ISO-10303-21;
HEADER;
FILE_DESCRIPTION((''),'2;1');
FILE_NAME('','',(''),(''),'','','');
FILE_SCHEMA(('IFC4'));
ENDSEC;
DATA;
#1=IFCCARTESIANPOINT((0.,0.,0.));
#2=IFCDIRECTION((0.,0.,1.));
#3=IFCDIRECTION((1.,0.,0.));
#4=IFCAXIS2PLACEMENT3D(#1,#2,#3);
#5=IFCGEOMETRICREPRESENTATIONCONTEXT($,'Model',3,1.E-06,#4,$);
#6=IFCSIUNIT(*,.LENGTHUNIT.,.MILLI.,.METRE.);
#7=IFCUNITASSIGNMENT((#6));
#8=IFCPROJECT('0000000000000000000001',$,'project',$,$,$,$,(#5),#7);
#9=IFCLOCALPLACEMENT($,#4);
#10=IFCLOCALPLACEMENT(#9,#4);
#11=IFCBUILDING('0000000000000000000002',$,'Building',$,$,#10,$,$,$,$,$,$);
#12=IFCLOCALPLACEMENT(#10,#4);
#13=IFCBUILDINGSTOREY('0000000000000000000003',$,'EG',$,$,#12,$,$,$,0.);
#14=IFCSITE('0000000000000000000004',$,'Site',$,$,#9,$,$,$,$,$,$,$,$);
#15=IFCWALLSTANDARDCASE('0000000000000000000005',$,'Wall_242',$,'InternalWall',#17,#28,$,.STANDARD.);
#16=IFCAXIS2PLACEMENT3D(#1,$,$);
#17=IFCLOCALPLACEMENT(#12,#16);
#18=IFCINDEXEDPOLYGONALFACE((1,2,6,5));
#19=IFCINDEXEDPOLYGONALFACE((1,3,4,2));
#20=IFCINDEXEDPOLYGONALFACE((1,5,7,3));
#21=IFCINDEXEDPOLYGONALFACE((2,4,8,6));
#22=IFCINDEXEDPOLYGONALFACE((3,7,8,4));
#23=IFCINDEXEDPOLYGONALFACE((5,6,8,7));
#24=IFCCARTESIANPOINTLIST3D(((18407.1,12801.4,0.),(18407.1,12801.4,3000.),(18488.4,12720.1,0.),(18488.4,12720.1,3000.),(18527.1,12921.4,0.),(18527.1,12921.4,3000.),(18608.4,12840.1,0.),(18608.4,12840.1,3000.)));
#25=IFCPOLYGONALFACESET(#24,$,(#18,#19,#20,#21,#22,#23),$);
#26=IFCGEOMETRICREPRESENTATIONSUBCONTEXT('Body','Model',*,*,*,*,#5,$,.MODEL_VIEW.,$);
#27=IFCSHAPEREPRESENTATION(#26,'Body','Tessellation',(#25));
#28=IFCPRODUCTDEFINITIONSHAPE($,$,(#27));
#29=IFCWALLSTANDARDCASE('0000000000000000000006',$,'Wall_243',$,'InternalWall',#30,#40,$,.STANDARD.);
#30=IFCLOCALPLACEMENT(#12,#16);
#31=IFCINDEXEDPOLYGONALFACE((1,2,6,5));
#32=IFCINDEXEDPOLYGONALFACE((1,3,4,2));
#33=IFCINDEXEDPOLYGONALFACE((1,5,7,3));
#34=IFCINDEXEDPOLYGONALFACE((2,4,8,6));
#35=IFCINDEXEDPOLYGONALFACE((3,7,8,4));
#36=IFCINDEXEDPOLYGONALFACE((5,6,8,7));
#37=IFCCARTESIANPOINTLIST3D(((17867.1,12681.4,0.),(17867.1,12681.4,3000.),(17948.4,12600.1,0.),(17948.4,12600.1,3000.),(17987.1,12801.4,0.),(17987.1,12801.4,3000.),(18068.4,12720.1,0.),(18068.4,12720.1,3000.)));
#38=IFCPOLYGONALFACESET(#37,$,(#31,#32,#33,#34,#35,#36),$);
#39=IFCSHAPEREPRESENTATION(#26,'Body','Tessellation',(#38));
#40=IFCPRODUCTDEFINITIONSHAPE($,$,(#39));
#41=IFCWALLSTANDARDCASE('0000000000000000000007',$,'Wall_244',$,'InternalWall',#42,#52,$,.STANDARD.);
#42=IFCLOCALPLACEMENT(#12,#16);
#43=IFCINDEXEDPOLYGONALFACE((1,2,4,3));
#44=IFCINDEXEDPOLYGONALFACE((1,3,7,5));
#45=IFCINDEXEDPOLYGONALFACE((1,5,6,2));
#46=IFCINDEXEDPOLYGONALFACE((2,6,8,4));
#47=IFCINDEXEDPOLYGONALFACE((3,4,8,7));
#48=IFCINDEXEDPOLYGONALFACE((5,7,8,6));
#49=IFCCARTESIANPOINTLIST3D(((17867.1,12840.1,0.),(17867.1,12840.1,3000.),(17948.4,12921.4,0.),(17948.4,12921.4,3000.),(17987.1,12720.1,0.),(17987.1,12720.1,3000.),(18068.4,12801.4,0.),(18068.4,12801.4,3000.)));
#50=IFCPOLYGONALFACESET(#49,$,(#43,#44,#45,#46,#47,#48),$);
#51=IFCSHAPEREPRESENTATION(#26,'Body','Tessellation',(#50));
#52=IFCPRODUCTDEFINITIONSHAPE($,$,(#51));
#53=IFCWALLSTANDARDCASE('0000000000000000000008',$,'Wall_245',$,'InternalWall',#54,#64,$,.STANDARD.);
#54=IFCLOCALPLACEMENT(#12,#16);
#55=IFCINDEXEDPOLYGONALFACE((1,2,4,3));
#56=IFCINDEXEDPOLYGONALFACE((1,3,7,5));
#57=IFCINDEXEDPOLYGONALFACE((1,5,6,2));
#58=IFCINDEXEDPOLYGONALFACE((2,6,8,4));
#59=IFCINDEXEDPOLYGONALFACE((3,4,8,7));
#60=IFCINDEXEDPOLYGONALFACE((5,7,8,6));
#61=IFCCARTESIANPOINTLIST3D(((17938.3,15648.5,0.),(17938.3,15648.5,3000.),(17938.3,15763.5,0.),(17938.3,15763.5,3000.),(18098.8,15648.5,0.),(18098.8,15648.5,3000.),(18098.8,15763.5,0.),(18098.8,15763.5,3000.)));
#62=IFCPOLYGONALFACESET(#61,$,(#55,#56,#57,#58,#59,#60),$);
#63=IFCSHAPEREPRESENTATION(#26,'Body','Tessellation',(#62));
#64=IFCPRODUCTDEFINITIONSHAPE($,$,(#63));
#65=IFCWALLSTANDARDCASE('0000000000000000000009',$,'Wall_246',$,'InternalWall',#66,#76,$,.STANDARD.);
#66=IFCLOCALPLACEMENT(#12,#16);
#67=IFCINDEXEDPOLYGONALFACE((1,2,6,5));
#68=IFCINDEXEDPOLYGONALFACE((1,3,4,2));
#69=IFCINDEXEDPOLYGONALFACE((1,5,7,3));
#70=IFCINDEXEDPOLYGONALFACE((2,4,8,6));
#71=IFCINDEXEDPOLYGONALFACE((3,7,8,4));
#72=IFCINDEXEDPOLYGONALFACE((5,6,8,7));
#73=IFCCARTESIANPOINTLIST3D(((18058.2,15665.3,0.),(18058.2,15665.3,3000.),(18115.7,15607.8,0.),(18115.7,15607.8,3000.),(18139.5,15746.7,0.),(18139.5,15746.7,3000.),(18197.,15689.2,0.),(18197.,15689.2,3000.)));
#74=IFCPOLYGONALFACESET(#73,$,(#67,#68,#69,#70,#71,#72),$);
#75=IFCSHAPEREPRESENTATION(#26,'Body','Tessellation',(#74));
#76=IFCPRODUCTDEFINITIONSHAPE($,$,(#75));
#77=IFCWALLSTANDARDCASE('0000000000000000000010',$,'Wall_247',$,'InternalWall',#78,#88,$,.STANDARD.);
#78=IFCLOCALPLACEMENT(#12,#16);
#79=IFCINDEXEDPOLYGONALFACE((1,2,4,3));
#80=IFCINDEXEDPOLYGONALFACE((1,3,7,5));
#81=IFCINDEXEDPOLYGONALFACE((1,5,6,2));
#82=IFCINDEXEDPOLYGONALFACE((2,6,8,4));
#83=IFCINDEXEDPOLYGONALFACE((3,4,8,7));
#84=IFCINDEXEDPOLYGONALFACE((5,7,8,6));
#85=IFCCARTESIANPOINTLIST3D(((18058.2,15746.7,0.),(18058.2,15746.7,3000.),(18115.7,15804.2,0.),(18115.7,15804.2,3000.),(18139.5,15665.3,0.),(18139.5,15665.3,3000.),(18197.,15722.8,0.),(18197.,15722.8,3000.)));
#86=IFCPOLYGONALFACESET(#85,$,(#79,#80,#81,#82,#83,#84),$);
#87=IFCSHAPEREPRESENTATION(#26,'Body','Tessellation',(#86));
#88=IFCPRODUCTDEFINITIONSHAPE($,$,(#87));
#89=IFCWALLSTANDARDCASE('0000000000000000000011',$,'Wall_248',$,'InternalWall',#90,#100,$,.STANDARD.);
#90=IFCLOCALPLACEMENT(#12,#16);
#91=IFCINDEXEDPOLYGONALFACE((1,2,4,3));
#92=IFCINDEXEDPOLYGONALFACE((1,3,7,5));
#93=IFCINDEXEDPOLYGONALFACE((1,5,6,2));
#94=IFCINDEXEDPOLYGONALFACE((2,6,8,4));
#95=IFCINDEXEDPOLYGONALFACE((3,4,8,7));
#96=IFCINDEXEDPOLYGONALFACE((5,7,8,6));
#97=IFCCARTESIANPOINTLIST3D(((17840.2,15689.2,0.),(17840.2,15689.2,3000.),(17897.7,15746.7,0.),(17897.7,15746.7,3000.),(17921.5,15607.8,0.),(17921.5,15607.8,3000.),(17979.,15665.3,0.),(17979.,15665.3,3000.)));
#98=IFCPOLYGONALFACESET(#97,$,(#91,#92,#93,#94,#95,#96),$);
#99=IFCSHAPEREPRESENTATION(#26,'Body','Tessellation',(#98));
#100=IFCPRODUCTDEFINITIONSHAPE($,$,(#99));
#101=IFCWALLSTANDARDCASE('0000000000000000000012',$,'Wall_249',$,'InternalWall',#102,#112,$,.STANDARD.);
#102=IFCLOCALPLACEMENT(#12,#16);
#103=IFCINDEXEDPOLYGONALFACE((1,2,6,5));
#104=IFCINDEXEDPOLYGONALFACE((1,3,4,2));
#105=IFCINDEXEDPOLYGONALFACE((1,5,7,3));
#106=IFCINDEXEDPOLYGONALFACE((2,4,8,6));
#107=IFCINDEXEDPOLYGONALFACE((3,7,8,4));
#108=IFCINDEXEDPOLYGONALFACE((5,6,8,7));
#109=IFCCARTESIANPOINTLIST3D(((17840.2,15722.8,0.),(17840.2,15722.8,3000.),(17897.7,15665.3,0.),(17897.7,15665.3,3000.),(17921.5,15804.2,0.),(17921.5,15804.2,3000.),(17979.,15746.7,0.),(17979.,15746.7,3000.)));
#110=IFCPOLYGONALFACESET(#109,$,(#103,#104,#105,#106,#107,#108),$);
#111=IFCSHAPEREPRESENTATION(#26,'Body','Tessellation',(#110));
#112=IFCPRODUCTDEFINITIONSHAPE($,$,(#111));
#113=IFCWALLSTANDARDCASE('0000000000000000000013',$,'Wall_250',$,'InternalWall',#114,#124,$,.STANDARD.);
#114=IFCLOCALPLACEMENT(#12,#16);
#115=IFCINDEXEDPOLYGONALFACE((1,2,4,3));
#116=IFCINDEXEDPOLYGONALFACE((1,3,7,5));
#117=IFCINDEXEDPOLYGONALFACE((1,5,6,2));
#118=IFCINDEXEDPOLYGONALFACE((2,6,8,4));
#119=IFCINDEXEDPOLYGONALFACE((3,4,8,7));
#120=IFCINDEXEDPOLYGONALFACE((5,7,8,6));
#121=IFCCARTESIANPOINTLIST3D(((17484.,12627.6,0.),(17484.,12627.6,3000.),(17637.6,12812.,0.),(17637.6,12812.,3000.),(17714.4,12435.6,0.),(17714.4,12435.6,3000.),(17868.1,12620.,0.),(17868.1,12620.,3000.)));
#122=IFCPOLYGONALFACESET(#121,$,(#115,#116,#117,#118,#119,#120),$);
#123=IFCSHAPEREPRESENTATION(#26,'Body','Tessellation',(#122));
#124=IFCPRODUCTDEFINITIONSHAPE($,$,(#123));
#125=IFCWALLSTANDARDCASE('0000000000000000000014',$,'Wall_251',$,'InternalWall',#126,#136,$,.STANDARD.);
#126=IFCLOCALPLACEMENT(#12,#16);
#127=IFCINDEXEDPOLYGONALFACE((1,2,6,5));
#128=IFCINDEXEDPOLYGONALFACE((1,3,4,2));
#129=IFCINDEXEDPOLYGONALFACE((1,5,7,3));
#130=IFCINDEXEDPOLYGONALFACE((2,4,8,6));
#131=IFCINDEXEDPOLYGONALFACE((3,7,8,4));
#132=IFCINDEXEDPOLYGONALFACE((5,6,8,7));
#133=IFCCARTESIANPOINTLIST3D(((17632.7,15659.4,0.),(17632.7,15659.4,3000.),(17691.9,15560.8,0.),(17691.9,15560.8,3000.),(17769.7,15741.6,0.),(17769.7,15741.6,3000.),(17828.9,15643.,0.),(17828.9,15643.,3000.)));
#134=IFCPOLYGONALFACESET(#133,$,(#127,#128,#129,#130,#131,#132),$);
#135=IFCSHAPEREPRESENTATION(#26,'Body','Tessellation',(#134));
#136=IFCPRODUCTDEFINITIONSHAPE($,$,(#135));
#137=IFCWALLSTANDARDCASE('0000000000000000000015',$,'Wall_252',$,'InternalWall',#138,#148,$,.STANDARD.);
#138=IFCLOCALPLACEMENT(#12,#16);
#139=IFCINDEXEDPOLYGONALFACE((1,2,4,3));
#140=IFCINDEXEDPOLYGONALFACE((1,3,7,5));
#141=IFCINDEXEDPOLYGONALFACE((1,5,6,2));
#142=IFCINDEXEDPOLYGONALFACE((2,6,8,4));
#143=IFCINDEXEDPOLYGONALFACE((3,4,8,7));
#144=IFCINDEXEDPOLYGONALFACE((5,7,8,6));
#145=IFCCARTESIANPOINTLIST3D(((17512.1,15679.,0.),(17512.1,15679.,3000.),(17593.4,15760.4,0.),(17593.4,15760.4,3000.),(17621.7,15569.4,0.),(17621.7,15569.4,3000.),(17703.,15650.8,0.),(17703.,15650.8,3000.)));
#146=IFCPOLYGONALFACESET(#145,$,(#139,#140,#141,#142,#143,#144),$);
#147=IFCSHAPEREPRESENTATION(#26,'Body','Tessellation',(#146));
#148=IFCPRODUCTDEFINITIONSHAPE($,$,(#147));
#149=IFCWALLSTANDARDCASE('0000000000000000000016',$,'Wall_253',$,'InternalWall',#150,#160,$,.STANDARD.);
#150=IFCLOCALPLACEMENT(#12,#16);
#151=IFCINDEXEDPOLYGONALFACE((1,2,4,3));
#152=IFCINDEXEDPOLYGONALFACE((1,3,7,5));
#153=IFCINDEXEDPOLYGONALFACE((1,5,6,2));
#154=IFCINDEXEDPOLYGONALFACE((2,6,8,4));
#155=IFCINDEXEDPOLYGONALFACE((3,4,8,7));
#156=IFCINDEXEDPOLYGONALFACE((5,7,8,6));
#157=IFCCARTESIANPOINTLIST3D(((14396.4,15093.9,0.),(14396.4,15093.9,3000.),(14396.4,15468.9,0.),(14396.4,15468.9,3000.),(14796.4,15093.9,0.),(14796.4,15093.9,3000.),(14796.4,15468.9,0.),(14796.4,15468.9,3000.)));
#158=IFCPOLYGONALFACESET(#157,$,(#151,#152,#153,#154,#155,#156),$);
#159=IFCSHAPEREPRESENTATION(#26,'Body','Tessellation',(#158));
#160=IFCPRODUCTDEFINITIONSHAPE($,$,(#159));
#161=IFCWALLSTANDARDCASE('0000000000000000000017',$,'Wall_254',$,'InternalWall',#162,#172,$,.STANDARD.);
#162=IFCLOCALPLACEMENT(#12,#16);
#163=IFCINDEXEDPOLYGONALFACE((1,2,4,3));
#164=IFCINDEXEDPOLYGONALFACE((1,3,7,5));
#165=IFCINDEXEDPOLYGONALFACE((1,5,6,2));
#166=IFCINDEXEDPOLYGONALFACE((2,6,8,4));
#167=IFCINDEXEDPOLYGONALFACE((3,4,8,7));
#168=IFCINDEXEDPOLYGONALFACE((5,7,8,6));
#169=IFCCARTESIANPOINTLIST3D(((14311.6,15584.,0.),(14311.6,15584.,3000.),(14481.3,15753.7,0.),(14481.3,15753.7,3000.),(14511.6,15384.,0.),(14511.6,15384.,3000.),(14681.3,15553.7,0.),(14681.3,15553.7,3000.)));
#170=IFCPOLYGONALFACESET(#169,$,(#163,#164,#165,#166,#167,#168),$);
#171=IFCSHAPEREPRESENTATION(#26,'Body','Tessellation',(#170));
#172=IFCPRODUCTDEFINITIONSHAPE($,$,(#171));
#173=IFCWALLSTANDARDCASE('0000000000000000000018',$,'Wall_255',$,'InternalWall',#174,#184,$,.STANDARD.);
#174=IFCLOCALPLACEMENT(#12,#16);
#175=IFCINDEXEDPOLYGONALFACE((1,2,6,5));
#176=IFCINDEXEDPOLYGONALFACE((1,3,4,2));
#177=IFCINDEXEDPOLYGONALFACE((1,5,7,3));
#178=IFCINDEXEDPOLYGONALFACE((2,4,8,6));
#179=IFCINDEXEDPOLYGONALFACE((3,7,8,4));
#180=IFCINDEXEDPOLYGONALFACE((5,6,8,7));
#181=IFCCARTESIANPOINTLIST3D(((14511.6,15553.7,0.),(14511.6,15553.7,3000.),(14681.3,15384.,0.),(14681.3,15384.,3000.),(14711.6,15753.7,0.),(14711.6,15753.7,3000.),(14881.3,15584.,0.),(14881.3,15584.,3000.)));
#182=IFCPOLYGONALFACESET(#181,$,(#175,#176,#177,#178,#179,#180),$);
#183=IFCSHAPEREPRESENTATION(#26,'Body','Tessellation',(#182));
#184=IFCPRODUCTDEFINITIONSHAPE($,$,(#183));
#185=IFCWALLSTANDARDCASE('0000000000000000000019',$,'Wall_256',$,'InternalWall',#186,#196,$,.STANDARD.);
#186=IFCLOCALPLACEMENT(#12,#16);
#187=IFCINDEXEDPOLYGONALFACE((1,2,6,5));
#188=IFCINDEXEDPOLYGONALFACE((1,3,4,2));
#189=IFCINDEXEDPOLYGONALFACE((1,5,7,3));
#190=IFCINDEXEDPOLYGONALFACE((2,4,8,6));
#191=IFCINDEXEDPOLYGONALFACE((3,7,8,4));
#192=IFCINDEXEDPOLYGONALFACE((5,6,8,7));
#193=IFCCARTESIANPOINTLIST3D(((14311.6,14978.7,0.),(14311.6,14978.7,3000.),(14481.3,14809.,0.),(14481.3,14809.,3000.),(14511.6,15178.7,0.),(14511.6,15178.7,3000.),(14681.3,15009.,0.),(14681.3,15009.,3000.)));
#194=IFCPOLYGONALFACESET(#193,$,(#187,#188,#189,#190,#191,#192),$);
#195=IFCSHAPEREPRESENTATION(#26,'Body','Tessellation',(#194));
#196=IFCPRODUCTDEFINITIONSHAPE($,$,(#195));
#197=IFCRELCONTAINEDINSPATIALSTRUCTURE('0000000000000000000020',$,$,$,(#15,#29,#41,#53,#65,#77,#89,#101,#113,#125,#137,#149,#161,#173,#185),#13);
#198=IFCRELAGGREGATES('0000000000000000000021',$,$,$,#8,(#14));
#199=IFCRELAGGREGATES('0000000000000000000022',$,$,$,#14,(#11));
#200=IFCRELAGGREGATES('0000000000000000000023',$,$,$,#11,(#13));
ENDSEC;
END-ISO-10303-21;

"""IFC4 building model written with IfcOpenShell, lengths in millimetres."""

from ifc_helpers import new_model, si_unit, frame, origin_with_axes, place, context, subcontext, project, spatial, rectangle, extrude, element, save


model = new_model("IFC4")

# Units and contexts
model_context = context("Model", 3, precision=1e-06, world=origin_with_axes())
body_context = subcontext(model_context, "Body", "Model", "MODEL_VIEW")
ifc_project = project(units=[si_unit("LENGTHUNIT", "METRE", prefix="MILLI")], contexts=[model_context])

# Site, building, storey
site_placement = place(None, origin_with_axes())
site = spatial("IfcSite", under=ifc_project, at=site_placement, Name="Site")
building_placement = place(site_placement, origin_with_axes())
building = spatial("IfcBuilding", under=site, at=building_placement, Name="Building")
storey_placement = place(building_placement, origin_with_axes())
storey = spatial("IfcBuildingStorey", under=building, at=storey_placement, Name="EG", Elevation=0.0)

# Walls
wall_1_placement = place(storey_placement, origin_with_axes())
element("IfcWallStandardCase", 1, at=wall_1_placement, inside=storey, Name="Wall_242", ObjectType="InternalWall", PredefinedType="STANDARD", context=body_context, shape_type="SweptSolid", body=[
    extrude(rectangle(XDim=169.7, YDim=115.0), frame((18507.8, 12820.8, 0.0), z_axis=(0.0, 0.0, 1.0), x_axis=(0.707107, 0.707107, 0.0)), (0.0, 0.0, 1.0), 3000.0),
])
wall_2_placement = place(storey_placement, origin_with_axes())
element("IfcWallStandardCase", 2, at=wall_2_placement, inside=storey, Name="Wall_243", ObjectType="InternalWall", PredefinedType="STANDARD", context=body_context, shape_type="SweptSolid", body=[
    extrude(rectangle(XDim=169.7, YDim=115.0), frame((17967.8, 12700.8, 0.0), z_axis=(0.0, 0.0, 1.0), x_axis=(-0.707107, -0.707107, 0.0)), (0.0, 0.0, 1.0), 3000.0),
])
wall_3_placement = place(storey_placement, origin_with_axes())
element("IfcWallStandardCase", 3, at=wall_3_placement, inside=storey, Name="Wall_244", ObjectType="InternalWall", PredefinedType="STANDARD", context=body_context, shape_type="SweptSolid", body=[
    extrude(rectangle(XDim=169.7, YDim=115.0), frame((17967.8, 12820.8, 0.0), z_axis=(0.0, 0.0, 1.0), x_axis=(-0.707107, 0.707107, 0.0)), (0.0, 0.0, 1.0), 3000.0),
])
wall_4_placement = place(storey_placement, origin_with_axes())
element("IfcWallStandardCase", 4, at=wall_4_placement, inside=storey, Name="Wall_245", ObjectType="InternalWall", PredefinedType="STANDARD", context=body_context, shape_type="SweptSolid", body=[
    extrude(rectangle(XDim=160.5, YDim=115.0), frame((18018.6, 15706.0, 0.0), z_axis=(0.0, 0.0, 1.0), x_axis=(-1.0, 0.0, 0.0)), (0.0, 0.0, 1.0), 3000.0),
])
wall_5_placement = place(storey_placement, origin_with_axes())
element("IfcWallStandardCase", 5, at=wall_5_placement, inside=storey, Name="Wall_246", ObjectType="InternalWall", PredefinedType="STANDARD", context=body_context, shape_type="SweptSolid", body=[
    extrude(rectangle(XDim=81.3, YDim=115.0), frame((18127.6, 15677.2, 0.0), z_axis=(0.0, 0.0, 1.0), x_axis=(0.707107, -0.707107, 0.0)), (0.0, 0.0, 1.0), 3000.0),
])
wall_6_placement = place(storey_placement, origin_with_axes())
element("IfcWallStandardCase", 6, at=wall_6_placement, inside=storey, Name="Wall_247", ObjectType="InternalWall", PredefinedType="STANDARD", context=body_context, shape_type="SweptSolid", body=[
    extrude(rectangle(XDim=81.3, YDim=115.0), frame((18127.6, 15734.7, 0.0), z_axis=(0.0, 0.0, 1.0), x_axis=(0.707107, 0.707107, 0.0)), (0.0, 0.0, 1.0), 3000.0),
])
wall_7_placement = place(storey_placement, origin_with_axes())
element("IfcWallStandardCase", 7, at=wall_7_placement, inside=storey, Name="Wall_248", ObjectType="InternalWall", PredefinedType="STANDARD", context=body_context, shape_type="SweptSolid", body=[
    extrude(rectangle(XDim=81.3, YDim=115.0), frame((17909.6, 15677.2, 0.0), z_axis=(0.0, 0.0, 1.0), x_axis=(-0.707107, -0.707107, 0.0)), (0.0, 0.0, 1.0), 3000.0),
])
wall_8_placement = place(storey_placement, origin_with_axes())
element("IfcWallStandardCase", 8, at=wall_8_placement, inside=storey, Name="Wall_249", ObjectType="InternalWall", PredefinedType="STANDARD", context=body_context, shape_type="SweptSolid", body=[
    extrude(rectangle(XDim=81.3, YDim=115.0), frame((17909.6, 15734.7, 0.0), z_axis=(0.0, 0.0, 1.0), x_axis=(-0.707107, 0.707107, 0.0)), (0.0, 0.0, 1.0), 3000.0),
])
wall_9_placement = place(storey_placement, origin_with_axes())
element("IfcWallStandardCase", 9, at=wall_9_placement, inside=storey, Name="Wall_250", ObjectType="InternalWall", PredefinedType="STANDARD", context=body_context, shape_type="SweptSolid", body=[
    extrude(rectangle(XDim=300.0, YDim=240.0), frame((17676.0, 12623.8, 0.0), z_axis=(0.0, 0.0, 1.0), x_axis=(0.768221, -0.640184, 0.0)), (0.0, 0.0, 1.0), 3000.0),
])
wall_10_placement = place(storey_placement, origin_with_axes())
element("IfcWallStandardCase", 10, at=wall_10_placement, inside=storey, Name="Wall_251", ObjectType="InternalWall", PredefinedType="STANDARD", context=body_context, shape_type="SweptSolid", body=[
    extrude(rectangle(XDim=159.8, YDim=115.0), frame((17730.8, 15651.2, 0.0), z_axis=(0.0, 0.0, 1.0), x_axis=(0.857493, 0.514496, 0.0)), (0.0, 0.0, 1.0), 3000.0),
])
wall_11_placement = place(storey_placement, origin_with_axes())
element("IfcWallStandardCase", 11, at=wall_11_placement, inside=storey, Name="Wall_252", ObjectType="InternalWall", PredefinedType="STANDARD", context=body_context, shape_type="SweptSolid", body=[
    extrude(rectangle(XDim=155.0, YDim=115.0), frame((17607.5, 15664.9, 0.0), z_axis=(0.0, 0.0, 1.0), x_axis=(-0.707107, 0.707107, 0.0)), (0.0, 0.0, 1.0), 3000.0),
])
wall_12_placement = place(storey_placement, origin_with_axes())
element("IfcWallStandardCase", 12, at=wall_12_placement, inside=storey, Name="Wall_253", ObjectType="InternalWall", PredefinedType="STANDARD", context=body_context, shape_type="SweptSolid", body=[
    extrude(rectangle(XDim=375.0, YDim=400.0), frame((14596.4, 15281.4, 0.0), z_axis=(0.0, 0.0, 1.0), x_axis=(0.0, -1.0, 0.0)), (0.0, 0.0, 1.0), 3000.0),
])
wall_13_placement = place(storey_placement, origin_with_axes())
element("IfcWallStandardCase", 13, at=wall_13_placement, inside=storey, Name="Wall_254", ObjectType="InternalWall", PredefinedType="STANDARD", context=body_context, shape_type="SweptSolid", body=[
    extrude(rectangle(XDim=282.8, YDim=240.0), frame((14496.4, 15568.9, 0.0), z_axis=(0.0, 0.0, 1.0), x_axis=(0.707107, -0.707107, 0.0)), (0.0, 0.0, 1.0), 3000.0),
])
wall_14_placement = place(storey_placement, origin_with_axes())
element("IfcWallStandardCase", 14, at=wall_14_placement, inside=storey, Name="Wall_255", ObjectType="InternalWall", PredefinedType="STANDARD", context=body_context, shape_type="SweptSolid", body=[
    extrude(rectangle(XDim=282.8, YDim=240.0), frame((14696.4, 15568.9, 0.0), z_axis=(0.0, 0.0, 1.0), x_axis=(0.707107, 0.707107, 0.0)), (0.0, 0.0, 1.0), 3000.0),
])
wall_15_placement = place(storey_placement, origin_with_axes())
element("IfcWallStandardCase", 15, at=wall_15_placement, inside=storey, Name="Wall_256", ObjectType="InternalWall", PredefinedType="STANDARD", context=body_context, shape_type="SweptSolid", body=[
    extrude(rectangle(XDim=282.8, YDim=240.0), frame((14496.4, 14993.9, 0.0), z_axis=(0.0, 0.0, 1.0), x_axis=(-0.707107, -0.707107, 0.0)), (0.0, 0.0, 1.0), 3000.0),
])

save(model, "model.ifc")
